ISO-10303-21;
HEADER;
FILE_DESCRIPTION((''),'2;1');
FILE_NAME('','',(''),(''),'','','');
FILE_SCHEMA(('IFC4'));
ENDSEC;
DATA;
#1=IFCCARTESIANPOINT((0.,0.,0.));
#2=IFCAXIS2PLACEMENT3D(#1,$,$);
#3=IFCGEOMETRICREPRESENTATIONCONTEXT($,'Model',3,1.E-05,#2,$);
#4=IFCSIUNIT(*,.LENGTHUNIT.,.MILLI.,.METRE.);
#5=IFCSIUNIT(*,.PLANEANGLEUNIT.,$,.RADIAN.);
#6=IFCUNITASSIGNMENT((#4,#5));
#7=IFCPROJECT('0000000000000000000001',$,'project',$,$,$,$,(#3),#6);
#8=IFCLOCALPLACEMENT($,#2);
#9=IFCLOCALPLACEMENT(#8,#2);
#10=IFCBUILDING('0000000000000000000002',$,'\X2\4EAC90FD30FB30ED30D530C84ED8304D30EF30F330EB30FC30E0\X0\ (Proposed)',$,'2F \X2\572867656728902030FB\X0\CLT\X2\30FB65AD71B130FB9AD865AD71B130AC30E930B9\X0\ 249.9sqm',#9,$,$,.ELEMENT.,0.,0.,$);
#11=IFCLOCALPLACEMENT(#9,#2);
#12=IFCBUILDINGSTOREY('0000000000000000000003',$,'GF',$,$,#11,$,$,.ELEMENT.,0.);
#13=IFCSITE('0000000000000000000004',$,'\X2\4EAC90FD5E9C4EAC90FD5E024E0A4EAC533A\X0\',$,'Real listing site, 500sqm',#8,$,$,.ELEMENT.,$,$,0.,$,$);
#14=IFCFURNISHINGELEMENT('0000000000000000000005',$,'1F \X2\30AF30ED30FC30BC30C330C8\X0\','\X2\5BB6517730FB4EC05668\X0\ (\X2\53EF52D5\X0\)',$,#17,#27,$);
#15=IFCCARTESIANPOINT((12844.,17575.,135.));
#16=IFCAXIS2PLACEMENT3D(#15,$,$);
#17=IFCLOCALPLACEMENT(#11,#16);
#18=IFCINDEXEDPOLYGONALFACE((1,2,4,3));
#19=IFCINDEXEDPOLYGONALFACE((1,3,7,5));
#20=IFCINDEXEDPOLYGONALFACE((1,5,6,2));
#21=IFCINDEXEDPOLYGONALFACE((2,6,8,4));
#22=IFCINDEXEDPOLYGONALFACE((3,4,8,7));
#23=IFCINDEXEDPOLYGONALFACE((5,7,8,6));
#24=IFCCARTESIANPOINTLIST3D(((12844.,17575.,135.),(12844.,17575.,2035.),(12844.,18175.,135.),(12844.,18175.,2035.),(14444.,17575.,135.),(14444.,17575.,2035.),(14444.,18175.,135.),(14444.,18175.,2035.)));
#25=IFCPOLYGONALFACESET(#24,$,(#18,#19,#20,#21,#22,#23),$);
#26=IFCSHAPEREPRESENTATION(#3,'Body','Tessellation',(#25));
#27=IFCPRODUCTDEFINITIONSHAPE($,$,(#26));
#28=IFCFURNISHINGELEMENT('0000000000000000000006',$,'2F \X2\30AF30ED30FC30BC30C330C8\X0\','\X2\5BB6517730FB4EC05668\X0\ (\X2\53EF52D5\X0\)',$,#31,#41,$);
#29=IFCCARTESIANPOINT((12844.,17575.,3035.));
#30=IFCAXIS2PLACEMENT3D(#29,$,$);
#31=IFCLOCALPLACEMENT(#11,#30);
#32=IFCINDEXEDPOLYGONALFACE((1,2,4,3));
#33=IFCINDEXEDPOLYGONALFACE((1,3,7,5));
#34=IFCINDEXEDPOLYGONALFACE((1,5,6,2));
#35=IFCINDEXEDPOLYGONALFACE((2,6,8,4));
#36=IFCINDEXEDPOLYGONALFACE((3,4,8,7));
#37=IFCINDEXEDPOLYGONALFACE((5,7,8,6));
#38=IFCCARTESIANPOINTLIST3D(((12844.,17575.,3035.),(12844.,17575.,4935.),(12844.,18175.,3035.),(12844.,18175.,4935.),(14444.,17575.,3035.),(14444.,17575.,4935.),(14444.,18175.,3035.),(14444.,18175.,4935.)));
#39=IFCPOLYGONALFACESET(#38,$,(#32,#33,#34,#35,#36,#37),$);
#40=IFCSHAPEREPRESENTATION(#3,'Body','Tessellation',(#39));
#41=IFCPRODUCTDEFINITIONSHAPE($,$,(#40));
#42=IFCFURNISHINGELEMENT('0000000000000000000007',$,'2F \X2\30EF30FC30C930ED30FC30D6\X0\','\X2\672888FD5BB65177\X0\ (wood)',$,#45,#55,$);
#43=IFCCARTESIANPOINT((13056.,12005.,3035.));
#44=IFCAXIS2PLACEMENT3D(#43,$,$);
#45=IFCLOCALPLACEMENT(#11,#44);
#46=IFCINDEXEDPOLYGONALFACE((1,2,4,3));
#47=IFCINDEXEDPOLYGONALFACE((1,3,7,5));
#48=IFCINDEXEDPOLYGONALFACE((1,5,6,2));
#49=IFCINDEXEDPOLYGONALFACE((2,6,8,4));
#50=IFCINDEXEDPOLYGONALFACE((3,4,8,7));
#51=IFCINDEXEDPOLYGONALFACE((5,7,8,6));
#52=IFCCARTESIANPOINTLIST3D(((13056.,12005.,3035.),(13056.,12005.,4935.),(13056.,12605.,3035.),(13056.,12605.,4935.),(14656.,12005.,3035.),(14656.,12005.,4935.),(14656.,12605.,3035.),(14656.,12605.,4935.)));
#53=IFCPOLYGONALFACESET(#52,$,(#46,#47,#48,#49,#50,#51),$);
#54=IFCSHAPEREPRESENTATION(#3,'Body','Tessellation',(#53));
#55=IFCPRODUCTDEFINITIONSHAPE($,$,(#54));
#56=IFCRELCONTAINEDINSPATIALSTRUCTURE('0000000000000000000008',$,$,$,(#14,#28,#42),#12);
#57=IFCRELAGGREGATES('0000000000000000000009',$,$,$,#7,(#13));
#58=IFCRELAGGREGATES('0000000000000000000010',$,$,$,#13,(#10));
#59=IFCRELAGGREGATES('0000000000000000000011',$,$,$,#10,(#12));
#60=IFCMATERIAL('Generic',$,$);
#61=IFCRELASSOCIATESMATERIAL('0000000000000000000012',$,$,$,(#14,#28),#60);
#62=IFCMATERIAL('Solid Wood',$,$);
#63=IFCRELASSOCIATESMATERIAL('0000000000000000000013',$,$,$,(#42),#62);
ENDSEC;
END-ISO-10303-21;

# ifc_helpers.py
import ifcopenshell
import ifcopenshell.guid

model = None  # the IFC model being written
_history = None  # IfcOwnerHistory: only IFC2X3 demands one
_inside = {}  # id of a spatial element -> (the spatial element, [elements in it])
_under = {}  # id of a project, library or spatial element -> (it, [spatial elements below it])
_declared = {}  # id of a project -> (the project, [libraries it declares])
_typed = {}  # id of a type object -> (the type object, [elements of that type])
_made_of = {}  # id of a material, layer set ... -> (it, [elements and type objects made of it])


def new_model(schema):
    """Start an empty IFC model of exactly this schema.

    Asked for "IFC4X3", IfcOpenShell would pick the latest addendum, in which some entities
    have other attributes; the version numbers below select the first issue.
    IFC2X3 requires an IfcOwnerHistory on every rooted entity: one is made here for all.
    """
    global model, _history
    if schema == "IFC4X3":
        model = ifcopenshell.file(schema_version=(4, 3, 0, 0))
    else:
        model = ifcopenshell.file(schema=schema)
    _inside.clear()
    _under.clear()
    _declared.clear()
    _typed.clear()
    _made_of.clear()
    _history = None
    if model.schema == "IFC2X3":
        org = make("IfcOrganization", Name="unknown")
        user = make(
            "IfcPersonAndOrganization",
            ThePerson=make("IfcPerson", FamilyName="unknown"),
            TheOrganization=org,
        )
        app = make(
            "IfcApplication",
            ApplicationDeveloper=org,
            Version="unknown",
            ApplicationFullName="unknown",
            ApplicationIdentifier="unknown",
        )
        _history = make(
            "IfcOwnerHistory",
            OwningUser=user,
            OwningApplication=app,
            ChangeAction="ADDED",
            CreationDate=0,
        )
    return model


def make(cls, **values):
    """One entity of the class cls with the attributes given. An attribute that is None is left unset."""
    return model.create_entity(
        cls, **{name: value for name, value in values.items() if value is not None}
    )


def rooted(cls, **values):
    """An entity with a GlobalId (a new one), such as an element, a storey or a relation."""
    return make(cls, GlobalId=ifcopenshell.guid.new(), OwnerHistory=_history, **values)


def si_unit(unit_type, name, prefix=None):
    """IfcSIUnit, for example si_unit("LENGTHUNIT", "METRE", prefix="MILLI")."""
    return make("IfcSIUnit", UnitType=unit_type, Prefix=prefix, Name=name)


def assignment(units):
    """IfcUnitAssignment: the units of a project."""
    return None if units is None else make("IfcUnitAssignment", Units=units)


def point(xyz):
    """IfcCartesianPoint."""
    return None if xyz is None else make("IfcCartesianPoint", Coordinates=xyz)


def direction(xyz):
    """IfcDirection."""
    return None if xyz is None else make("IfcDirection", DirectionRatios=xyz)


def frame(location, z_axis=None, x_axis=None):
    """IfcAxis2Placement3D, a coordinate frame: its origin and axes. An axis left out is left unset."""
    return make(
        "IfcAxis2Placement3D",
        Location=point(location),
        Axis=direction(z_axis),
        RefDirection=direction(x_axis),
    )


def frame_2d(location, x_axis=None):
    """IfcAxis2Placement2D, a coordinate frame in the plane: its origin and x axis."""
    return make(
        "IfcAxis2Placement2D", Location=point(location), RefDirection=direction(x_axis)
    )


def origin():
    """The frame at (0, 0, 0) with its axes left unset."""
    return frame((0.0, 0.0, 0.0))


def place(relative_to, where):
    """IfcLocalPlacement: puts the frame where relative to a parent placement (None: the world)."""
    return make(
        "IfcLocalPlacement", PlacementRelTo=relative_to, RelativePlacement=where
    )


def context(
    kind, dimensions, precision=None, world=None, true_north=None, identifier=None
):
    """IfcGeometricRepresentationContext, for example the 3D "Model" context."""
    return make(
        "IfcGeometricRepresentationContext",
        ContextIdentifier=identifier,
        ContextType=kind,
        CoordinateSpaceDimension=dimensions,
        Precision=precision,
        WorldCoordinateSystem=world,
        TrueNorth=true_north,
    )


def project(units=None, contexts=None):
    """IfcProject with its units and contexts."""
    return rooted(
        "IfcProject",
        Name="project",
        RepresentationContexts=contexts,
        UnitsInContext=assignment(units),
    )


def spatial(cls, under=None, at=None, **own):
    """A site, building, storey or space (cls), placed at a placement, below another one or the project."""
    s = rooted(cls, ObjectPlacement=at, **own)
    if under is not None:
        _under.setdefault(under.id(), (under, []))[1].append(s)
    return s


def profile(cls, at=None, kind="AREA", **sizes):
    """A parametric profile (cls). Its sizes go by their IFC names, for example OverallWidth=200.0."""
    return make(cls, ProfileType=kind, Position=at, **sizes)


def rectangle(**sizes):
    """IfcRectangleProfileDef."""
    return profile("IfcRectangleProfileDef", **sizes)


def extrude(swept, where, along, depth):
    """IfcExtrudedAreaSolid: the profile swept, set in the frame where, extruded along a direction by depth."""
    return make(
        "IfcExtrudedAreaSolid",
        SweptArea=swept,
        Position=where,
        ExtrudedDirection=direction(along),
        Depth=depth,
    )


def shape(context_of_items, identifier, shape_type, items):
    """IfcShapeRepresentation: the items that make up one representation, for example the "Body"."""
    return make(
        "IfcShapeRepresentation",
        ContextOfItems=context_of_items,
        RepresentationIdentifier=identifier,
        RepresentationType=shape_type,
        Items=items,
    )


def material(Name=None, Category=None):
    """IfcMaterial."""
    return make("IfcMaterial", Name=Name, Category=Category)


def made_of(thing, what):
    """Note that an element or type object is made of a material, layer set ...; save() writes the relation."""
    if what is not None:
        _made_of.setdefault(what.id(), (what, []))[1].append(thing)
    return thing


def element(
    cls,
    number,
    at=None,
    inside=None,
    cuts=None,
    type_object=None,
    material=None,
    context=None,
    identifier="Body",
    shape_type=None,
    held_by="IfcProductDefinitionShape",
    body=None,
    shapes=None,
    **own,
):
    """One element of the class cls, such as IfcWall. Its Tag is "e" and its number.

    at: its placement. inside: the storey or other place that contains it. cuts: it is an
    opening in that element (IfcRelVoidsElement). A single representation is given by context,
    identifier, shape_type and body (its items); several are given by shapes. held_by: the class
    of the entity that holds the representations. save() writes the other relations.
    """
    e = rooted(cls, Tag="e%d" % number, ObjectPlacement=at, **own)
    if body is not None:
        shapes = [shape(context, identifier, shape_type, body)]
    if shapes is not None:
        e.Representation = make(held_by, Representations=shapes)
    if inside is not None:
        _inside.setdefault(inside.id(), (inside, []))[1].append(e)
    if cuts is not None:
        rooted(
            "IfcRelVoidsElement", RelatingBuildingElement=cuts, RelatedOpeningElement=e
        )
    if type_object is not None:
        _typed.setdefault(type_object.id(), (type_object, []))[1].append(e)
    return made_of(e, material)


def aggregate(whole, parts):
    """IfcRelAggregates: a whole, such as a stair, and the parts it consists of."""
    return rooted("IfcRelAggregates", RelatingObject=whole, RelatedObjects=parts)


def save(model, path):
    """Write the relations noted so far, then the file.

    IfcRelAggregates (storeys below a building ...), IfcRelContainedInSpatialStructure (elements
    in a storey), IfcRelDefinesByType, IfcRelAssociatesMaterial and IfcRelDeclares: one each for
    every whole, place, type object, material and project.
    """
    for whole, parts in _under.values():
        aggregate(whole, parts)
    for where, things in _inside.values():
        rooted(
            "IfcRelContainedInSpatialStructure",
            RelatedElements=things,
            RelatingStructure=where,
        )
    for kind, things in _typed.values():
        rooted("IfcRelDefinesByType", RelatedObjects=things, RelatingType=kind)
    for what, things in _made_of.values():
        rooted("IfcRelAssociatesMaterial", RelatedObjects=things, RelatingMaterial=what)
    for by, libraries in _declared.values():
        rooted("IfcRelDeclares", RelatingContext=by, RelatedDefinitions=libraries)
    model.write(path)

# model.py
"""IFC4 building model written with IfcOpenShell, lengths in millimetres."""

from ifc_helpers import new_model, si_unit, frame, frame_2d, origin, place, context, project, spatial, rectangle, extrude, material, element, save


model = new_model("IFC4")

# Units and contexts
model_context = context("Model", 3, precision=1e-05, world=origin())
ifc_project = project(units=[si_unit("LENGTHUNIT", "METRE", prefix="MILLI"), si_unit("PLANEANGLEUNIT", "RADIAN")], contexts=[model_context])

# Site, building, storey
site_placement = place(None, origin())
site = spatial("IfcSite", under=ifc_project, at=site_placement, Name="京都府京都市上京区", ObjectType="Real listing site, 500sqm", CompositionType="ELEMENT", RefElevation=0.0)
building_placement = place(site_placement, origin())
building = spatial("IfcBuilding", under=site, at=building_placement, Name="京都・ロフト付きワンルーム (Proposed)", ObjectType="2F 在来木造・CLT・断熱・高断熱ガラス 249.9sqm", CompositionType="ELEMENT", ElevationOfRefHeight=0.0, ElevationOfTerrain=0.0)
storey_placement = place(building_placement, origin())
storey = spatial("IfcBuildingStorey", under=building, at=storey_placement, Name="GF", CompositionType="ELEMENT", Elevation=0.0)

# Shared definitions
ifc_material_1 = material(Name="Solid Wood")

# Shared definitions
ifc_material_2 = material(Name="Generic")

# Furnishing elements
furnishing_1_placement = place(storey_placement, frame((12844.0, 17575.0, 135.0)))
element("IfcFurnishingElement", 1, at=furnishing_1_placement, inside=storey, material=ifc_material_2, Name="1F クローゼット", Description="家具・什器 (可動)", context=model_context, shape_type="SweptSolid", body=[
    extrude(rectangle(XDim=1600.0, YDim=600.0, at=frame_2d((800.0, 300.0))), frame((12844.0, 17575.0, 135.0)), (0.0, 0.0, 1.0), 1900.0),
])
furnishing_2_placement = place(storey_placement, frame((12844.0, 17575.0, 3035.0)))
element("IfcFurnishingElement", 2, at=furnishing_2_placement, inside=storey, material=ifc_material_2, Name="2F クローゼット", Description="家具・什器 (可動)", context=model_context, shape_type="SweptSolid", body=[
    extrude(rectangle(XDim=1600.0, YDim=600.0, at=frame_2d((800.0, 300.0))), frame((12844.0, 17575.0, 3035.0)), (0.0, 0.0, 1.0), 1900.0),
])
furnishing_3_placement = place(storey_placement, frame((13056.0, 12005.0, 3035.0)))
element("IfcFurnishingElement", 3, at=furnishing_3_placement, inside=storey, material=ifc_material_1, Name="2F ワードローブ", Description="木製家具 (wood)", context=model_context, shape_type="SweptSolid", body=[
    extrude(rectangle(XDim=1600.0, YDim=600.0, at=frame_2d((800.0, 300.0))), frame((13056.0, 12005.0, 3035.0)), (0.0, 0.0, 1.0), 1900.0),
])

save(model, "model.ifc")
